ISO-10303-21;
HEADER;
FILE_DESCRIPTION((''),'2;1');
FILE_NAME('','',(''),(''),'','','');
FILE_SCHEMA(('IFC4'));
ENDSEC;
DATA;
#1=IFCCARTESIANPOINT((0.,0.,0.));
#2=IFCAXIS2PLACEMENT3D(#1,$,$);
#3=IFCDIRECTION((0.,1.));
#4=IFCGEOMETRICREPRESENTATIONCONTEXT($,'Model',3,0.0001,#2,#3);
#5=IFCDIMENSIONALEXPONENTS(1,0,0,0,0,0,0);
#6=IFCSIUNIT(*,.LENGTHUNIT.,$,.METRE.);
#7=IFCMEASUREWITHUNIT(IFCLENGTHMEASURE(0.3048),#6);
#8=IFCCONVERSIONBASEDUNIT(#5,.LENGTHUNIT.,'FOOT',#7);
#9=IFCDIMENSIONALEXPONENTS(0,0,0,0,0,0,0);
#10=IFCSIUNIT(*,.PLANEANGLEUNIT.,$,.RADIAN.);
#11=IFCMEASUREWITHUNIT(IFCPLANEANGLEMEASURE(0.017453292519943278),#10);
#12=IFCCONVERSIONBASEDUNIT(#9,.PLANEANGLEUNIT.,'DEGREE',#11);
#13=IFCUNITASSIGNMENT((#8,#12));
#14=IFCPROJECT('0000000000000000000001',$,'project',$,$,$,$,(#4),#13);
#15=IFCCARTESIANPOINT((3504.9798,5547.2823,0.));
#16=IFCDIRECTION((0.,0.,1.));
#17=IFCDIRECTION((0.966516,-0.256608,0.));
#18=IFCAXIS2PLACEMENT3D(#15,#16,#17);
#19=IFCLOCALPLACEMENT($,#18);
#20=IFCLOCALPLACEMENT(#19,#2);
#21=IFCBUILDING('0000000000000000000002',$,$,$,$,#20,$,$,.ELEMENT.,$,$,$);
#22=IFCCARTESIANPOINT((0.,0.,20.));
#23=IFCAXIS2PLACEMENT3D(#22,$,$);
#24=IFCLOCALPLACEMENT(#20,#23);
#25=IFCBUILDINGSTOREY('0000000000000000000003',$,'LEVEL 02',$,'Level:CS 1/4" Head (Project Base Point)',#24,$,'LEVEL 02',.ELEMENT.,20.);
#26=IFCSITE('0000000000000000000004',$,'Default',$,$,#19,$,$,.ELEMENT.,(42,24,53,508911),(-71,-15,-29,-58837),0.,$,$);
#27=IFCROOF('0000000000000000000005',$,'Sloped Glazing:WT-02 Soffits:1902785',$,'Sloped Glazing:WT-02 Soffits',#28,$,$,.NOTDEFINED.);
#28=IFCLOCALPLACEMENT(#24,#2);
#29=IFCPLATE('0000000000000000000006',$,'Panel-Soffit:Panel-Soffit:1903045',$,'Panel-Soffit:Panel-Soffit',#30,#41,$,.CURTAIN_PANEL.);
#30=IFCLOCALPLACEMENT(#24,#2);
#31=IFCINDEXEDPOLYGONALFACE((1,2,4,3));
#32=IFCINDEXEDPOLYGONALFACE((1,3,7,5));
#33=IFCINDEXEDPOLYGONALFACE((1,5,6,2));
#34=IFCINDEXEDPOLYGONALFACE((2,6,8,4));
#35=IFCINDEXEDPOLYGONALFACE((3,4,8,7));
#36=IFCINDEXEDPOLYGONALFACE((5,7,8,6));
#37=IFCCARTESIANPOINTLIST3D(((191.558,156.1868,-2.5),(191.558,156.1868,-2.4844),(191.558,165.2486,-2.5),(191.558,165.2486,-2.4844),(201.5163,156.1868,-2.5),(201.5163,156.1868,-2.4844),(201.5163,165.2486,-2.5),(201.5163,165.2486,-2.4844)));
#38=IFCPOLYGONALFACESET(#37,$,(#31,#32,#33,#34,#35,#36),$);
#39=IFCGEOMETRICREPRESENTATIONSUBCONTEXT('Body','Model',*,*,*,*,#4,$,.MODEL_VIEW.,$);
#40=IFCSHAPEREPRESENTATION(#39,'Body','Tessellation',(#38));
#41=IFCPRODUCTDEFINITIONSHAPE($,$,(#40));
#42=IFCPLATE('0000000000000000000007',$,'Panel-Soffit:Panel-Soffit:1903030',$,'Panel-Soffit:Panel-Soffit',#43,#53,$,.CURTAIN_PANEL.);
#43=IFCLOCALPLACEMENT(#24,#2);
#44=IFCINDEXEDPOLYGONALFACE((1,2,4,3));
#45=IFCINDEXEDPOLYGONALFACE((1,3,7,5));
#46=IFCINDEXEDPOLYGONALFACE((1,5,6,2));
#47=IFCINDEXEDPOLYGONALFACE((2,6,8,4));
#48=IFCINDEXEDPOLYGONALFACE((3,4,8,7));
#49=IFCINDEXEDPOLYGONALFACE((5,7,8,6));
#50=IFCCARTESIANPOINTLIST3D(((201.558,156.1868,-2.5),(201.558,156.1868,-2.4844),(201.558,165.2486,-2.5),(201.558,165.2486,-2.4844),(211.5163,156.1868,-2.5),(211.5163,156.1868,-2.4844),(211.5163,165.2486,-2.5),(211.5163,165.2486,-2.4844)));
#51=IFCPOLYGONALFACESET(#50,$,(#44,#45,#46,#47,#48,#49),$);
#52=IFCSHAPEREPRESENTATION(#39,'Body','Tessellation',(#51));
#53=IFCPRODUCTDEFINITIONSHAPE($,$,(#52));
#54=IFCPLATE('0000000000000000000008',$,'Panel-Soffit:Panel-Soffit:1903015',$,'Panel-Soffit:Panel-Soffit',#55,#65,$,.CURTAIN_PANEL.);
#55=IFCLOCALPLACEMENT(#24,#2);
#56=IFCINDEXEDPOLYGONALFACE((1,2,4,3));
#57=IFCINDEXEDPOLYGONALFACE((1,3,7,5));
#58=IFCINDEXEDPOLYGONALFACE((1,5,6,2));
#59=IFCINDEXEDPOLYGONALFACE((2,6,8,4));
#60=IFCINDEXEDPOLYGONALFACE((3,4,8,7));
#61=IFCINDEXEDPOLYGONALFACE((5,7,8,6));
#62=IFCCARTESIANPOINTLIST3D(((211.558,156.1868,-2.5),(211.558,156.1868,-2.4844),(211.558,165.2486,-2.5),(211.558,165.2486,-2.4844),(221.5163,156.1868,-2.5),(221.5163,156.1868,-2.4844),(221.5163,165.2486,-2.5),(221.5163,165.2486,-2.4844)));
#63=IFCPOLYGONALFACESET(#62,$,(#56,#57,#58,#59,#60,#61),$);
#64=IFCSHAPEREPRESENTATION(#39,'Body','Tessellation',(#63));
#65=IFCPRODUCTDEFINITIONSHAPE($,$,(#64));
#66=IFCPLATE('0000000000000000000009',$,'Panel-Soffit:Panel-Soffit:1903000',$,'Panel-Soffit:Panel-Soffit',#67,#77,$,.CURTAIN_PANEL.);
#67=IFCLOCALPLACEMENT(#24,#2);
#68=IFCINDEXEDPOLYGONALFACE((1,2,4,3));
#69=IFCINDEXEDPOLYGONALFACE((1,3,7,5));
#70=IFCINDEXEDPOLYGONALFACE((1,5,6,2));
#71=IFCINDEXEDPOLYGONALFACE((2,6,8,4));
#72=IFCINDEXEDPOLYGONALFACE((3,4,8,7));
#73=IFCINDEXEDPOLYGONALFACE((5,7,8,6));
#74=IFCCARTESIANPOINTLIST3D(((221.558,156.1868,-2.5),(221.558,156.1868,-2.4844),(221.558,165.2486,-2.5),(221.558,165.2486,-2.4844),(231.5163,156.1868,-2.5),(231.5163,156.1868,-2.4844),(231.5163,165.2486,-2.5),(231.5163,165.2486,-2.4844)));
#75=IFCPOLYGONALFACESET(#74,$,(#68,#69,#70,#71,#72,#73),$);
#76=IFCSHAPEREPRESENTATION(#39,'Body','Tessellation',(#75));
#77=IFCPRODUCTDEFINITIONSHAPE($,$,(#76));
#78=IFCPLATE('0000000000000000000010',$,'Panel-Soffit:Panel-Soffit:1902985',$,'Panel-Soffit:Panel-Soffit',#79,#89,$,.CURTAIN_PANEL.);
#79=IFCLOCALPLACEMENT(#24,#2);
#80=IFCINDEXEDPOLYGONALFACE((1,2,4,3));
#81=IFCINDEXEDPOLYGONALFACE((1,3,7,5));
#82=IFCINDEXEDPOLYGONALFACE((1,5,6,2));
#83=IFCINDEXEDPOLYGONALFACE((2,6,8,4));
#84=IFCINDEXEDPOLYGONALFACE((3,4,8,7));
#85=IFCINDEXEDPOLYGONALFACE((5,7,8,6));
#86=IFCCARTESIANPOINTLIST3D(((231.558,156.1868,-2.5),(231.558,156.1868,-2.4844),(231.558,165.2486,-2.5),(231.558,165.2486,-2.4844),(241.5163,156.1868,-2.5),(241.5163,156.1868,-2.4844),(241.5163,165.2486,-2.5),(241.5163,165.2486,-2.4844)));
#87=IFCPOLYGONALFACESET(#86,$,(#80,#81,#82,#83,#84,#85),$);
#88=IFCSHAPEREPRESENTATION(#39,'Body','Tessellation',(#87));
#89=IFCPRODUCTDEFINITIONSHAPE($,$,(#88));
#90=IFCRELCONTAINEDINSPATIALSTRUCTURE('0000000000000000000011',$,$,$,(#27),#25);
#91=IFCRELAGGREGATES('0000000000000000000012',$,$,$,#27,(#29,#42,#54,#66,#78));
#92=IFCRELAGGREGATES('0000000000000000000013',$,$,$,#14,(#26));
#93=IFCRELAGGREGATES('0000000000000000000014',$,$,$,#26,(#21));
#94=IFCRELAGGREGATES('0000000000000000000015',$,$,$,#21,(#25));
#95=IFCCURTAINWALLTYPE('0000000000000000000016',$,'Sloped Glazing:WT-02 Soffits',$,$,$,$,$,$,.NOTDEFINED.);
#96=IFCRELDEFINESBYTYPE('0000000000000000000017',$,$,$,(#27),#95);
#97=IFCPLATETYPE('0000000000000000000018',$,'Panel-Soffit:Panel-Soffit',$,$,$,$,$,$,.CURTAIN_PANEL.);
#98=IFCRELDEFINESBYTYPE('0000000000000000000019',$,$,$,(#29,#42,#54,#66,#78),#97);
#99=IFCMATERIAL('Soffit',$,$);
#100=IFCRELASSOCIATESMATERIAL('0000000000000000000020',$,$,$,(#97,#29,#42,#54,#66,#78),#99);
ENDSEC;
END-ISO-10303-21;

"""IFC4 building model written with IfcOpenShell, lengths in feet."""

from ifc_helpers import new_model, entity, si_unit, converted_unit, direction, frame, origin, place, context, subcontext, project, spatial, indexed_curve, outline, extrude, source, transform, mapped, material, type_object, type_shapes, element, aggregate, save


model = new_model("IFC4")

# Units and contexts
model_context = context("Model", 3, precision=0.0001, world=origin(), true_north=direction((0.0, 1.0)))
body_context = subcontext(model_context, "Body", "Model", "MODEL_VIEW")
ifc_project = project(units=[converted_unit("LENGTHUNIT", "FOOT", entity("IfcLengthMeasure", 0.3048), si_unit("LENGTHUNIT", "METRE"), dimensions=[1, 0, 0, 0, 0, 0, 0]), converted_unit("PLANEANGLEUNIT", "DEGREE", entity("IfcPlaneAngleMeasure", 0.017453292519943278), si_unit("PLANEANGLEUNIT", "RADIAN"), dimensions=[0, 0, 0, 0, 0, 0, 0])], contexts=[model_context])

# Site, building, storey
site_placement = place(None, frame((3504.9798, 5547.2823, 0.0), z_axis=(0.0, 0.0, 1.0), x_axis=(0.966516, -0.256608, 0.0)))
site = spatial("IfcSite", under=ifc_project, at=site_placement, Name="Default", CompositionType="ELEMENT", RefLatitude=(42, 24, 53, 508911), RefLongitude=(-71, -15, -29, -58837), RefElevation=0.0)
building_placement = place(site_placement, origin())
building = spatial("IfcBuilding", under=site, at=building_placement, CompositionType="ELEMENT")
storey_placement = place(building_placement, frame((0.0, 0.0, 20.0)))
storey = spatial("IfcBuildingStorey", under=building, at=storey_placement, Name="LEVEL 02", ObjectType="Level:CS 1/4\" Head (Project Base Point)", LongName="LEVEL 02", CompositionType="ELEMENT", Elevation=20.0)

# Roof, plates
curtain_wall_type_1 = type_object("IfcCurtainWallType", Name="Sloped Glazing:WT-02 Soffits", PredefinedType="NOTDEFINED")
roof_placement = place(storey_placement, frame((0.0, 0.0, -20.0)))
roof = element("IfcRoof", 1, at=roof_placement, inside=storey, type_object=curtain_wall_type_1, Name="Sloped Glazing:WT-02 Soffits:1902785", ObjectType="Sloped Glazing:WT-02 Soffits", PredefinedType="NOTDEFINED")
ifc_material_1 = material(Name="Soffit")
plate_type_1 = type_object("IfcPlateType", Name="Panel-Soffit:Panel-Soffit", PredefinedType="CURTAIN_PANEL", material=ifc_material_1)
shared_shape_1 = source(origin(), body_context, "Body", "SweptSolid", [
    extrude(outline(indexed_curve([(-0.0078, -4.9792), (0.0078, -4.9792), (0.0078, 4.9792), (-0.0078, 4.9792), (-0.0078, -4.9792)], self_intersect=False)), frame((0.0, -0.0078, 0.0208), z_axis=(0.0, 0.0, 1.0), x_axis=(0.0, -1.0, 0.0)), (0.0, 0.0, 1.0), 9.0617),
])
type_shapes(plate_type_1, [shared_shape_1])
plate_1_placement = place(roof_placement, frame((196.5372, 156.166, 17.5), z_axis=(0.0, 1.0, 0.0), x_axis=(1.0, 0.0, 0.0)))
plate_1 = element("IfcPlate", 2, at=plate_1_placement, type_object=plate_type_1, material=ifc_material_1, Name="Panel-Soffit:Panel-Soffit:1903045", ObjectType="Panel-Soffit:Panel-Soffit", PredefinedType="CURTAIN_PANEL", context=body_context, shape_type="MappedRepresentation", body=[
    mapped(shared_shape_1, transform((0.0, 0.0, 0.0), scale=1.0)),
])
plate_2_placement = place(roof_placement, frame((206.5372, 156.166, 17.5), z_axis=(0.0, 1.0, 0.0), x_axis=(1.0, 0.0, 0.0)))
plate_2 = element("IfcPlate", 3, at=plate_2_placement, type_object=plate_type_1, material=ifc_material_1, Name="Panel-Soffit:Panel-Soffit:1903030", ObjectType="Panel-Soffit:Panel-Soffit", PredefinedType="CURTAIN_PANEL", context=body_context, shape_type="MappedRepresentation", body=[
    mapped(shared_shape_1, transform((0.0, 0.0, 0.0), scale=1.0)),
])
plate_3_placement = place(roof_placement, frame((216.5372, 156.166, 17.5), z_axis=(0.0, 1.0, 0.0), x_axis=(1.0, 0.0, 0.0)))
plate_3 = element("IfcPlate", 4, at=plate_3_placement, type_object=plate_type_1, material=ifc_material_1, Name="Panel-Soffit:Panel-Soffit:1903015", ObjectType="Panel-Soffit:Panel-Soffit", PredefinedType="CURTAIN_PANEL", context=body_context, shape_type="MappedRepresentation", body=[
    mapped(shared_shape_1, transform((0.0, 0.0, 0.0), scale=1.0)),
])
plate_4_placement = place(roof_placement, frame((226.5372, 156.166, 17.5), z_axis=(0.0, 1.0, 0.0), x_axis=(1.0, 0.0, 0.0)))
plate_4 = element("IfcPlate", 5, at=plate_4_placement, type_object=plate_type_1, material=ifc_material_1, Name="Panel-Soffit:Panel-Soffit:1903000", ObjectType="Panel-Soffit:Panel-Soffit", PredefinedType="CURTAIN_PANEL", context=body_context, shape_type="MappedRepresentation", body=[
    mapped(shared_shape_1, transform((0.0, 0.0, 0.0), scale=1.0)),
])
plate_5_placement = place(roof_placement, frame((236.5372, 156.166, 17.5), z_axis=(0.0, 1.0, 0.0), x_axis=(1.0, 0.0, 0.0)))
plate_5 = element("IfcPlate", 6, at=plate_5_placement, type_object=plate_type_1, material=ifc_material_1, Name="Panel-Soffit:Panel-Soffit:1902985", ObjectType="Panel-Soffit:Panel-Soffit", PredefinedType="CURTAIN_PANEL", context=body_context, shape_type="MappedRepresentation", body=[
    mapped(shared_shape_1, transform((0.0, 0.0, 0.0), scale=1.0)),
])
aggregate(roof, [plate_1, plate_2, plate_3, plate_4, plate_5])

save(model, "model.ifc")
